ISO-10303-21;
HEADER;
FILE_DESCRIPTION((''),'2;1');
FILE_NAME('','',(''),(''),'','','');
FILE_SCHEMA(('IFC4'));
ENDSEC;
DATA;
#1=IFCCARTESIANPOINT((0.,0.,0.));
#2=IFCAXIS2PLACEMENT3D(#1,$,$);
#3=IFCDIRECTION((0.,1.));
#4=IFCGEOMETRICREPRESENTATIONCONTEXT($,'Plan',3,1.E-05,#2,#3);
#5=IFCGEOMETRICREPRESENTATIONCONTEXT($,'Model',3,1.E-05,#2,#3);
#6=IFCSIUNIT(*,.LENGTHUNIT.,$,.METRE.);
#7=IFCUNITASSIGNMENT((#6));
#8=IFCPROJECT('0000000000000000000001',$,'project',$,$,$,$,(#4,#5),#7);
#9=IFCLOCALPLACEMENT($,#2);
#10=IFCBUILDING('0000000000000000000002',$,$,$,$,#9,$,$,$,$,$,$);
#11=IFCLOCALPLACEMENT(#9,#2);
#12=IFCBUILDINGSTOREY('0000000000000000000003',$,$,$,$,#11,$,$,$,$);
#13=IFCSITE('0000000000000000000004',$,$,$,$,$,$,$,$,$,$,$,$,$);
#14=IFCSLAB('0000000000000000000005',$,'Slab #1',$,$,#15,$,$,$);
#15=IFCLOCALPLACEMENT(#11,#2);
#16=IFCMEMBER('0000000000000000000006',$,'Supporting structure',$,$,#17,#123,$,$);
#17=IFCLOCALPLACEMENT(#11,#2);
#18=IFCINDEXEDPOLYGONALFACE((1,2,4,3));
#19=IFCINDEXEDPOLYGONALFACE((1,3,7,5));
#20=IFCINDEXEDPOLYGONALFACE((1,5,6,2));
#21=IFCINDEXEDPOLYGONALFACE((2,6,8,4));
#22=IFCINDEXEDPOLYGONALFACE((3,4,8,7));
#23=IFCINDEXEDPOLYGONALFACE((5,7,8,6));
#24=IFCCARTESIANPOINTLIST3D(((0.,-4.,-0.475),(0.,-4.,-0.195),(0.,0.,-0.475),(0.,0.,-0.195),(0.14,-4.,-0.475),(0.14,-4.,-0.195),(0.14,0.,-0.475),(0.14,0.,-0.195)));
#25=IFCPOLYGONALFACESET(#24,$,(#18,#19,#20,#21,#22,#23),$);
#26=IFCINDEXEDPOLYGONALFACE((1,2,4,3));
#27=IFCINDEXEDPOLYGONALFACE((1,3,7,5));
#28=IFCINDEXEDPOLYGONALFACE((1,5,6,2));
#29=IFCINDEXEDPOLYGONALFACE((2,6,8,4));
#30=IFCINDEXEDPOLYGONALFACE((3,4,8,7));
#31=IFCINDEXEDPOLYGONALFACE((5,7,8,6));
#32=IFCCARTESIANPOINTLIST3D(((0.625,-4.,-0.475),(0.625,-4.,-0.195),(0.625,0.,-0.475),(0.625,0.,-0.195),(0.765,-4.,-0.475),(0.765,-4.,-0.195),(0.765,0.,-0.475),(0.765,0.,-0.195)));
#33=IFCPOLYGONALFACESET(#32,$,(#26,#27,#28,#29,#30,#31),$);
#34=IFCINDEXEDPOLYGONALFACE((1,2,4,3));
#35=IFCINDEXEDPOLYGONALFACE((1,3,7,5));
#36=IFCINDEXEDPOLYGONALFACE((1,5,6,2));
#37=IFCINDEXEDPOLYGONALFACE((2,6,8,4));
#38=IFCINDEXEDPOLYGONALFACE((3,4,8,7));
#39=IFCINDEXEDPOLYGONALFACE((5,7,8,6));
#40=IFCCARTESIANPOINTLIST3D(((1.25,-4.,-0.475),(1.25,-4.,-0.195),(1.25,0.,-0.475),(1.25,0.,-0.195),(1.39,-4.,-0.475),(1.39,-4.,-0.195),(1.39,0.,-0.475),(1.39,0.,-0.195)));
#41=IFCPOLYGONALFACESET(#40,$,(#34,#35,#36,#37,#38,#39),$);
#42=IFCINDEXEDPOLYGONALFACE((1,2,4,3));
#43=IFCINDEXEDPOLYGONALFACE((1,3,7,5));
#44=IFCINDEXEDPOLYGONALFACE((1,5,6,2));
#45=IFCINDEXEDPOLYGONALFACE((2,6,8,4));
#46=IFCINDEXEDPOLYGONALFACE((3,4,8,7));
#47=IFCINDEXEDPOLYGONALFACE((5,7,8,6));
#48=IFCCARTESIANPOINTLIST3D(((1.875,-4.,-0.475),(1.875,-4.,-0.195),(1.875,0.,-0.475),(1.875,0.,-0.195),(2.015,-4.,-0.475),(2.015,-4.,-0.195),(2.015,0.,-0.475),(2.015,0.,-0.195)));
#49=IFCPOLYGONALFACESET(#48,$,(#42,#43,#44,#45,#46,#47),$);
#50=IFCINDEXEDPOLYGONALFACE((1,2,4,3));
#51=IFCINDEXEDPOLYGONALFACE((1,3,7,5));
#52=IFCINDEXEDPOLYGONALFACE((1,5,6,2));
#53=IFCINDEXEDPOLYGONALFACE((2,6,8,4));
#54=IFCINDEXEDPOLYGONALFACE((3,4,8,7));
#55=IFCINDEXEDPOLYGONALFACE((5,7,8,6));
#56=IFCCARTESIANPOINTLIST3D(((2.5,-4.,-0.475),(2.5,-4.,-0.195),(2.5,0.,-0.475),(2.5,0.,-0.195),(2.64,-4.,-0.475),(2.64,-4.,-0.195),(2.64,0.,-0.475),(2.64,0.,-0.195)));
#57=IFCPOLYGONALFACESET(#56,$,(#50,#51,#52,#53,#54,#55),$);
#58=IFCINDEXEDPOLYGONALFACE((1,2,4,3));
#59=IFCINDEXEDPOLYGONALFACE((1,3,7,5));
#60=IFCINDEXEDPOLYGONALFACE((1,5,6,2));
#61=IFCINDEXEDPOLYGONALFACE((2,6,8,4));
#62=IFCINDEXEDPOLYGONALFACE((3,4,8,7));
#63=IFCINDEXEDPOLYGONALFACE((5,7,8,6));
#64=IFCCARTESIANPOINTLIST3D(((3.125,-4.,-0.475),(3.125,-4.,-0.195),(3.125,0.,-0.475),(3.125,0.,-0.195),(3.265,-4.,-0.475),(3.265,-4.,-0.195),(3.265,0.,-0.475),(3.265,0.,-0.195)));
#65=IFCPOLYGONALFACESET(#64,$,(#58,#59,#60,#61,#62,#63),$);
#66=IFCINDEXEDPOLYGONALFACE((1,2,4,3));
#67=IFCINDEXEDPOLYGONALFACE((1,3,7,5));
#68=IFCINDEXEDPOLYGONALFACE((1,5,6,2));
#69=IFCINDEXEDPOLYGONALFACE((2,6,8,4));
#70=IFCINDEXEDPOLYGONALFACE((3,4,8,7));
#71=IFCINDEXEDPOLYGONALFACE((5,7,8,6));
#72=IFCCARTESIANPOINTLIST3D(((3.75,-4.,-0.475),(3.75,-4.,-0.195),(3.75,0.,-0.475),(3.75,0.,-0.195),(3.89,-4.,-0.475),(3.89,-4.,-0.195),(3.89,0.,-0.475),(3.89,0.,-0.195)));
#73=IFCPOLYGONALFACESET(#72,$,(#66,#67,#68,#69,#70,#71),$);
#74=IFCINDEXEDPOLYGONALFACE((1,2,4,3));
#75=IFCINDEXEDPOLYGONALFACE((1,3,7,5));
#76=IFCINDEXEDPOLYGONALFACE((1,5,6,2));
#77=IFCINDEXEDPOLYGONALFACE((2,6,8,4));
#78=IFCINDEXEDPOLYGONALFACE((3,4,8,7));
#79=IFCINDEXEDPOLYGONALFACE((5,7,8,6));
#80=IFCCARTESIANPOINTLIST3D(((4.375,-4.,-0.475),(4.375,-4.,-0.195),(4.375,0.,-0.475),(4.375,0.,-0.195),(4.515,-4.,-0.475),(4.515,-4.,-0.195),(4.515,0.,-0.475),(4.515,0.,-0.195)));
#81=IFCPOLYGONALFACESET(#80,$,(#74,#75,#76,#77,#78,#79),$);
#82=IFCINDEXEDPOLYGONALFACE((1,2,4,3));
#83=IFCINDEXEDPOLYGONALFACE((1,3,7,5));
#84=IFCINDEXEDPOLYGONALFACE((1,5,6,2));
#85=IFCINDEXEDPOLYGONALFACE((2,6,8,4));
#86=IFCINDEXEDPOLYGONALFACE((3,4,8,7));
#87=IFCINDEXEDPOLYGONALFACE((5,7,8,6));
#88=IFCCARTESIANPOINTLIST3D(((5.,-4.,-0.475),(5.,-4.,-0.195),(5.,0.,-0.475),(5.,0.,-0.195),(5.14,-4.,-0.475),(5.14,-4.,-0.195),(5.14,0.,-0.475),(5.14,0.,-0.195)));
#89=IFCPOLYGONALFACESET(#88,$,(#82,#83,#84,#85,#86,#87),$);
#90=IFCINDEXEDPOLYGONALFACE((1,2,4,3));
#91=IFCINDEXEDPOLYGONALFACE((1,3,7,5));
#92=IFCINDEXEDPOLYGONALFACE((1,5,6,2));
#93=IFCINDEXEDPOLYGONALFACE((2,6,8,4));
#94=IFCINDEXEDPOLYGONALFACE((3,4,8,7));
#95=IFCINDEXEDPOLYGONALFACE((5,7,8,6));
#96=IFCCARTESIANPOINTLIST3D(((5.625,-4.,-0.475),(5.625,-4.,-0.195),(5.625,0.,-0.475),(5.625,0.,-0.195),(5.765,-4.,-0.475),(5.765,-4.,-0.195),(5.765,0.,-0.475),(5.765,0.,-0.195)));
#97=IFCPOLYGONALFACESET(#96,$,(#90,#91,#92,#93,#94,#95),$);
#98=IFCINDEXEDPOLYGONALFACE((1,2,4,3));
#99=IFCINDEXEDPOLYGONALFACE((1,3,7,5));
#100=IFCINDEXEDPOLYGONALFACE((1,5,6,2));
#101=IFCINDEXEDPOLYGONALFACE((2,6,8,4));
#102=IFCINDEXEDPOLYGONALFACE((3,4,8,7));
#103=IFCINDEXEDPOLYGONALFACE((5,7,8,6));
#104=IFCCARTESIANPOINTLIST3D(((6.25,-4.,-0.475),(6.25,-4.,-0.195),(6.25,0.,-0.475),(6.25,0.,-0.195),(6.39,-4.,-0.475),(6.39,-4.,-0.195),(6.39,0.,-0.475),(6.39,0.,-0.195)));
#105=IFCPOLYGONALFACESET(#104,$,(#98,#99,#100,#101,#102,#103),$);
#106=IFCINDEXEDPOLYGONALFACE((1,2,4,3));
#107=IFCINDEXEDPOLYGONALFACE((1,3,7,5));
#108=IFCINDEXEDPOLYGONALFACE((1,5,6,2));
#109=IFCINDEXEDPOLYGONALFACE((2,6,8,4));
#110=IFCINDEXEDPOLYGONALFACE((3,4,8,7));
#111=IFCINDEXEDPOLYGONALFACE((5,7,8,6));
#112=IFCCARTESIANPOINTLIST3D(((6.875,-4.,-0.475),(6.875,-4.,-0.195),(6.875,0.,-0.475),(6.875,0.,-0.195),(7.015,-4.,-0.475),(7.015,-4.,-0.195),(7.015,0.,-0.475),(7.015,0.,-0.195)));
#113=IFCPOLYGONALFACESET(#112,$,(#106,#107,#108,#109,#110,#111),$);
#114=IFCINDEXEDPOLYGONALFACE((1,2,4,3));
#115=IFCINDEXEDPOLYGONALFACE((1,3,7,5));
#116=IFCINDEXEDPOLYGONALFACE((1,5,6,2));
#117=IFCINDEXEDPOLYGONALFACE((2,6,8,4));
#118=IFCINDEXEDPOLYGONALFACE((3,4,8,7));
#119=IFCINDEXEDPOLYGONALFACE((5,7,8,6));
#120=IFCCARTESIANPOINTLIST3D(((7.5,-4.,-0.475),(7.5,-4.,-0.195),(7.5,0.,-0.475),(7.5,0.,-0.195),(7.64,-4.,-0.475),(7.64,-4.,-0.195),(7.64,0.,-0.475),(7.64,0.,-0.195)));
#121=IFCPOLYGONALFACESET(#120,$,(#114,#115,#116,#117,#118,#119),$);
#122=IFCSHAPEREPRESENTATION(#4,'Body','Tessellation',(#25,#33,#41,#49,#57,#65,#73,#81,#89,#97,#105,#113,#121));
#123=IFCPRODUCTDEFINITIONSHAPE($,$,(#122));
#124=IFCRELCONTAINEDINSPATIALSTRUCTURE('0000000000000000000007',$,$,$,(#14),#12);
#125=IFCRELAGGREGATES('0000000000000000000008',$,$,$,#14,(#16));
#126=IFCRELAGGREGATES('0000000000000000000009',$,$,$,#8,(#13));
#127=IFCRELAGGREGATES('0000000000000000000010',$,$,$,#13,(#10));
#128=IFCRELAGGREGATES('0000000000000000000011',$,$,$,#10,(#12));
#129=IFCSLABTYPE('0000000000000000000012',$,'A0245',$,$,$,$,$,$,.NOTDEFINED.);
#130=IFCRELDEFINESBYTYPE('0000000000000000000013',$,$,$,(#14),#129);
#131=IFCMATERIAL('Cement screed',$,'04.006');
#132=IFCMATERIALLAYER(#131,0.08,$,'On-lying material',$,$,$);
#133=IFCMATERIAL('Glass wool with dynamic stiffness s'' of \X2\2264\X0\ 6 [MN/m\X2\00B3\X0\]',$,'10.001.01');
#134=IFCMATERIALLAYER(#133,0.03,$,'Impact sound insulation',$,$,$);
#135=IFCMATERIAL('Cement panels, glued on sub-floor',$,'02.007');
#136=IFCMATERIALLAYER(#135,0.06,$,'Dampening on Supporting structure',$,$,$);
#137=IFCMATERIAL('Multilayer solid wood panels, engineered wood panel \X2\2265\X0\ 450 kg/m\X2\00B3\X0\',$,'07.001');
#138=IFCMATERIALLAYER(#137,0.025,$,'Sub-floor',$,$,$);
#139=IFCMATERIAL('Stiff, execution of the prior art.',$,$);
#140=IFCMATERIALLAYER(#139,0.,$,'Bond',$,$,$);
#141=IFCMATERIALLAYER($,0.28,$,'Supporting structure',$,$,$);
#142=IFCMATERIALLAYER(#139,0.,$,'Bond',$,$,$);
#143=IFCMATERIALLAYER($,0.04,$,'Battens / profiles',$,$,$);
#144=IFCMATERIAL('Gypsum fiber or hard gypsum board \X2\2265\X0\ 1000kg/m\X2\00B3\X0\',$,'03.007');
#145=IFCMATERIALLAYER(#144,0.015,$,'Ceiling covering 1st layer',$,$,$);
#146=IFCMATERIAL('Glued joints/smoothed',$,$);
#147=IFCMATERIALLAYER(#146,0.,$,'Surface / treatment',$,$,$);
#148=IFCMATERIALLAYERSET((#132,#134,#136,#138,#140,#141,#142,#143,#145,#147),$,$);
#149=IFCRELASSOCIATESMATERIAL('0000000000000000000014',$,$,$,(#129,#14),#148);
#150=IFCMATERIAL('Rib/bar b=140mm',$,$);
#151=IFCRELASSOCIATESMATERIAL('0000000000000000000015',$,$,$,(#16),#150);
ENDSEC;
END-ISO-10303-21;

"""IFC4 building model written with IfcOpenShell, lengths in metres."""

from ifc_helpers import new_model, si_unit, direction, frame, frame_2d, origin, place, context, project, spatial, rectangle, extrude, material, layer, layer_set, type_object, element, aggregate, save


model = new_model("IFC4")

# Units and contexts
plan_context = context("Plan", 3, precision=1e-05, world=origin(), true_north=direction((0.0, 1.0)))
model_context = context("Model", 3, precision=1e-05, world=origin(), true_north=direction((0.0, 1.0)))
ifc_project = project(units=[si_unit("LENGTHUNIT", "METRE")], contexts=[plan_context, model_context])

# Site, building, storey
site = spatial("IfcSite", under=ifc_project)
building_placement = place(None, origin())
building = spatial("IfcBuilding", under=site, at=building_placement)
storey_placement = place(building_placement, origin())
storey = spatial("IfcBuildingStorey", under=building, at=storey_placement)

# Slab, member
ifc_material_1 = material(Name="Cement screed", Category="04.006")
ifc_layer_1 = layer(ifc_material_1, 0.08, Name="On-lying material")
ifc_material_2 = material(Name="Glass wool with dynamic stiffness s' of ≤ 6 [MN/m³]", Category="10.001.01")
ifc_layer_2 = layer(ifc_material_2, 0.03, Name="Impact sound insulation")
ifc_material_3 = material(Name="Cement panels, glued on sub-floor", Category="02.007")
ifc_layer_3 = layer(ifc_material_3, 0.06, Name="Dampening on Supporting structure")
ifc_material_4 = material(Name="Multilayer solid wood panels, engineered wood panel ≥ 450 kg/m³", Category="07.001")
ifc_layer_4 = layer(ifc_material_4, 0.025, Name="Sub-floor")
ifc_material_5 = material(Name="Stiff, execution of the prior art.")
ifc_layer_5 = layer(ifc_material_5, 0.0, Name="Bond")
ifc_layer_6 = layer(None, 0.28, Name="Supporting structure")
ifc_layer_7 = layer(ifc_material_5, 0.0, Name="Bond")
ifc_layer_8 = layer(None, 0.04, Name="Battens / profiles")
ifc_material_6 = material(Name="Gypsum fiber or hard gypsum board ≥ 1000kg/m³", Category="03.007")
ifc_layer_9 = layer(ifc_material_6, 0.015, Name="Ceiling covering 1st layer")
ifc_material_7 = material(Name="Glued joints/smoothed")
ifc_layer_10 = layer(ifc_material_7, 0.0, Name="Surface / treatment")
ifc_layer_set = layer_set([ifc_layer_1, ifc_layer_2, ifc_layer_3, ifc_layer_4, ifc_layer_5, ifc_layer_6, ifc_layer_7, ifc_layer_8, ifc_layer_9, ifc_layer_10])
slab_type = type_object("IfcSlabType", Name="A0245", PredefinedType="NOTDEFINED", material=ifc_layer_set)
slab_placement = place(None, frame((0.0, 0.0, 0.0), z_axis=(0.0, 0.0, -1.0), x_axis=(1.0, 0.0, 0.0)))
slab = element("IfcSlab", 1, at=slab_placement, inside=storey, type_object=slab_type, material=ifc_layer_set, Name="Slab #1")
ifc_material_8 = material(Name="Rib/bar b=140mm")
member_1_placement = place(slab_placement, origin())
member_1 = element("IfcMember", 2, at=member_1_placement, material=ifc_material_8, Name="Supporting structure", context=plan_context, shape_type="SweptSolid", body=[
    extrude(rectangle(XDim=0.14, YDim=0.28, at=frame_2d((0.07, 0.14), x_axis=(1.0, 0.0))), frame((0.0, 4.0, 0.195), z_axis=(0.0, -1.0, 0.0), x_axis=(1.0, 0.0, 0.0)), (0.0, 0.0, 1.0), 4.0),
    extrude(rectangle(XDim=0.14, YDim=0.28, at=frame_2d((0.07, 0.14), x_axis=(1.0, 0.0))), frame((0.625, 4.0, 0.195), z_axis=(0.0, -1.0, 0.0), x_axis=(1.0, 0.0, 0.0)), (0.0, 0.0, 1.0), 4.0),
    extrude(rectangle(XDim=0.14, YDim=0.28, at=frame_2d((0.07, 0.14), x_axis=(1.0, 0.0))), frame((1.25, 4.0, 0.195), z_axis=(0.0, -1.0, 0.0), x_axis=(1.0, 0.0, 0.0)), (0.0, 0.0, 1.0), 4.0),
    extrude(rectangle(XDim=0.14, YDim=0.28, at=frame_2d((0.07, 0.14), x_axis=(1.0, 0.0))), frame((1.875, 4.0, 0.195), z_axis=(0.0, -1.0, 0.0), x_axis=(1.0, 0.0, 0.0)), (0.0, 0.0, 1.0), 4.0),
    extrude(rectangle(XDim=0.14, YDim=0.28, at=frame_2d((0.07, 0.14), x_axis=(1.0, 0.0))), frame((2.5, 4.0, 0.195), z_axis=(0.0, -1.0, 0.0), x_axis=(1.0, 0.0, 0.0)), (0.0, 0.0, 1.0), 4.0),
    extrude(rectangle(XDim=0.14, YDim=0.28, at=frame_2d((0.07, 0.14), x_axis=(1.0, 0.0))), frame((3.125, 4.0, 0.195), z_axis=(0.0, -1.0, 0.0), x_axis=(1.0, 0.0, 0.0)), (0.0, 0.0, 1.0), 4.0),
    extrude(rectangle(XDim=0.14, YDim=0.28, at=frame_2d((0.07, 0.14), x_axis=(1.0, 0.0))), frame((3.75, 4.0, 0.195), z_axis=(0.0, -1.0, 0.0), x_axis=(1.0, 0.0, 0.0)), (0.0, 0.0, 1.0), 4.0),
    extrude(rectangle(XDim=0.14, YDim=0.28, at=frame_2d((0.07, 0.14), x_axis=(1.0, 0.0))), frame((4.375, 4.0, 0.195), z_axis=(0.0, -1.0, 0.0), x_axis=(1.0, 0.0, 0.0)), (0.0, 0.0, 1.0), 4.0),
    extrude(rectangle(XDim=0.14, YDim=0.28, at=frame_2d((0.07, 0.14), x_axis=(1.0, 0.0))), frame((5.0, 4.0, 0.195), z_axis=(0.0, -1.0, 0.0), x_axis=(1.0, 0.0, 0.0)), (0.0, 0.0, 1.0), 4.0),
    extrude(rectangle(XDim=0.14, YDim=0.28, at=frame_2d((0.07, 0.14), x_axis=(1.0, 0.0))), frame((5.625, 4.0, 0.195), z_axis=(0.0, -1.0, 0.0), x_axis=(1.0, 0.0, 0.0)), (0.0, 0.0, 1.0), 4.0),
    extrude(rectangle(XDim=0.14, YDim=0.28, at=frame_2d((0.07, 0.14), x_axis=(1.0, 0.0))), frame((6.25, 4.0, 0.195), z_axis=(0.0, -1.0, 0.0), x_axis=(1.0, 0.0, 0.0)), (0.0, 0.0, 1.0), 4.0),
    extrude(rectangle(XDim=0.14, YDim=0.28, at=frame_2d((0.07, 0.14), x_axis=(1.0, 0.0))), frame((6.875, 4.0, 0.195), z_axis=(0.0, -1.0, 0.0), x_axis=(1.0, 0.0, 0.0)), (0.0, 0.0, 1.0), 4.0),
    extrude(rectangle(XDim=0.14, YDim=0.28, at=frame_2d((0.07, 0.14), x_axis=(1.0, 0.0))), frame((7.5, 4.0, 0.195), z_axis=(0.0, -1.0, 0.0), x_axis=(1.0, 0.0, 0.0)), (0.0, 0.0, 1.0), 4.0),
])
aggregate(slab, [member_1])

save(model, "model.ifc")
